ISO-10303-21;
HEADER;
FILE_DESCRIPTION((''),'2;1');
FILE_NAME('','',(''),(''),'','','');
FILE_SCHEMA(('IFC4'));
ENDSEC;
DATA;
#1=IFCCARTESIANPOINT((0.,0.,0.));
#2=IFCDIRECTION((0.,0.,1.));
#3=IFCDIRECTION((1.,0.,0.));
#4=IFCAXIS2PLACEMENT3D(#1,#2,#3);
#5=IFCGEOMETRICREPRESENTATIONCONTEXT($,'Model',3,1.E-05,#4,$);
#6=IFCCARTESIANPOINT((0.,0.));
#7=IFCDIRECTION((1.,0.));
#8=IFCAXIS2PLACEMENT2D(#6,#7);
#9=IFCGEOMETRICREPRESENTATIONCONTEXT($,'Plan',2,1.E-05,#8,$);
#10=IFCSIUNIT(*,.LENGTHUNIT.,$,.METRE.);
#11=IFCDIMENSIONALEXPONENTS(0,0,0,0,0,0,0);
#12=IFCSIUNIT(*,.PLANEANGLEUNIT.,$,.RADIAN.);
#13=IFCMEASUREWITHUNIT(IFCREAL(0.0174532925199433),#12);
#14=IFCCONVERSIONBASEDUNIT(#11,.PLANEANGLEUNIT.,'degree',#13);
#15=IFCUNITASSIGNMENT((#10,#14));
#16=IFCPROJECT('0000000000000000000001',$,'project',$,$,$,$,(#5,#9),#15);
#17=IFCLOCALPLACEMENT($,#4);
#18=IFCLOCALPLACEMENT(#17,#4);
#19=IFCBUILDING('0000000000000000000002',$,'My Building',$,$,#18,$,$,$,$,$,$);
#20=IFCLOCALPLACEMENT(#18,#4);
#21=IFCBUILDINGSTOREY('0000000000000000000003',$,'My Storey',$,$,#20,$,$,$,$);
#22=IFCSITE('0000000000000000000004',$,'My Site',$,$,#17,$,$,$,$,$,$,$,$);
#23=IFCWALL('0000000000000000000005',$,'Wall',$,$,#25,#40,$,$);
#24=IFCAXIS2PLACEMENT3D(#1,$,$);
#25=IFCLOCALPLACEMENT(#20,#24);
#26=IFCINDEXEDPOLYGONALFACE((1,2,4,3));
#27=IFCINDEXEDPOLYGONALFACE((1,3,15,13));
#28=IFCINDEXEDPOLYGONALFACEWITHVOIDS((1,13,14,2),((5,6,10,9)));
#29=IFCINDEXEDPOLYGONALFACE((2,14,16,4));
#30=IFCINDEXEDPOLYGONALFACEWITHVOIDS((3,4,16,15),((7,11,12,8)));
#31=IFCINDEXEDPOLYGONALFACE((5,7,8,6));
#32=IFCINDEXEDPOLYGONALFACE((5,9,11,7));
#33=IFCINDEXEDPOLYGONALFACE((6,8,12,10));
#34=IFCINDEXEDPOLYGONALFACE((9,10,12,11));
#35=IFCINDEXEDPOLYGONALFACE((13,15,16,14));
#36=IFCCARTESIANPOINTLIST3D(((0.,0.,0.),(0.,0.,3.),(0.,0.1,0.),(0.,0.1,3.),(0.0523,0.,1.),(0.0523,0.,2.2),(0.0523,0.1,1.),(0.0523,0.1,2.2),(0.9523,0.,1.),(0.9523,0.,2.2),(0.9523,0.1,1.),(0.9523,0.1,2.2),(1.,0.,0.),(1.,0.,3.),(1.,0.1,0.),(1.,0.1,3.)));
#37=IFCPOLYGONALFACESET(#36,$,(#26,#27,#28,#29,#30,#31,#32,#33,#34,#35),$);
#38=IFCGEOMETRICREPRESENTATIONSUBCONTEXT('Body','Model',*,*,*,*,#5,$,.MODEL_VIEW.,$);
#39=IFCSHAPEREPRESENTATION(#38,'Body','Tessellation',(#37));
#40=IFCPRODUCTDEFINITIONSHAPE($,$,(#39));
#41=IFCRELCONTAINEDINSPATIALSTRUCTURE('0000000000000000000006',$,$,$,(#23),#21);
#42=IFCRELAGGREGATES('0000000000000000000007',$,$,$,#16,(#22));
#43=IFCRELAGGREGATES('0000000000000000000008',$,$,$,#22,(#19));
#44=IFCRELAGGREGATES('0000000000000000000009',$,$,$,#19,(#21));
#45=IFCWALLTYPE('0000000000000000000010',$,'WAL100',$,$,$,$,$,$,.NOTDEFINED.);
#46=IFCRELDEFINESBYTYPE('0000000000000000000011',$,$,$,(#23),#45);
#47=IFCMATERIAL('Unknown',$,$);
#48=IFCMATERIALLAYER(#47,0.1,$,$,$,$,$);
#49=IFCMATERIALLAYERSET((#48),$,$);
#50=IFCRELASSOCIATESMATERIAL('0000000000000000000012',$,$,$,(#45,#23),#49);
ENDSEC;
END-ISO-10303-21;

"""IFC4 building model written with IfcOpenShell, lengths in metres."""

from ifc_helpers import new_model, entity, si_unit, converted_unit, frame, origin_with_axes, origin_2d_with_axis, place, context, subcontext, project, spatial, line, indexed_curve, outline, extrude, source, transform, mapped, material, layer, layer_set, layer_usage, type_object, element, save


model = new_model("IFC4")

# Units and contexts
model_context = context("Model", 3, precision=1e-05, world=origin_with_axes())
plan_context = context("Plan", 2, precision=1e-05, world=origin_2d_with_axis())
body_context = subcontext(model_context, "Body", "Model", "MODEL_VIEW")
ifc_project = project(units=[si_unit("LENGTHUNIT", "METRE"), converted_unit("PLANEANGLEUNIT", "degree", entity("IfcReal", 0.0174532925199433), si_unit("PLANEANGLEUNIT", "RADIAN"), dimensions=[0, 0, 0, 0, 0, 0, 0])], contexts=[model_context, plan_context])

# Site, building, storey
site_placement = place(None, origin_with_axes())
site = spatial("IfcSite", under=ifc_project, at=site_placement, Name="My Site")
building_placement = place(site_placement, origin_with_axes())
building = spatial("IfcBuilding", under=site, at=building_placement, Name="My Building")
storey_placement = place(building_placement, origin_with_axes())
storey = spatial("IfcBuildingStorey", under=building, at=storey_placement, Name="My Storey")

# Wall, opening
ifc_material = material(Name="Unknown")
ifc_layer = layer(ifc_material, 0.1)
ifc_layer_set = layer_set([ifc_layer])
ifc_layer_usage = layer_usage(ifc_layer_set, "AXIS2", "POSITIVE", 0.0)
wall_type = type_object("IfcWallType", Name="WAL100", PredefinedType="NOTDEFINED", material=ifc_layer_set)
wall_placement = place(storey_placement, origin_with_axes())
wall = element("IfcWall", 1, at=wall_placement, inside=storey, type_object=wall_type, material=ifc_layer_usage, Name="Wall", context=body_context, shape_type="SweptSolid", body=[
    extrude(outline(indexed_curve([(0.0, 0.0), (0.0, 0.1), (1.0, 0.1), (1.0, 0.0), (0.0, 0.0)], self_intersect=False)), origin_with_axes(), (0.0, 0.0, 1.0), 3.0),
])
shared_shape = source(origin_with_axes(), body_context, "Body", "SweptSolid", [
    extrude(outline(indexed_curve([(0.0, 0.0), (0.9, 0.0), (0.9, 1.2), (0.0, 1.2)], segments=[line(1, 2, 3, 4, 1)])), frame((0.0, -0.6, 0.0), z_axis=(0.0, -1.0, 0.0), x_axis=(1.0, 0.0, 0.0)), (0.0, 0.0, -1.0), 1.2),
])
opening_placement = place(wall_placement, frame((0.0523, 0.0, 1.0), z_axis=(0.0, 0.0, 1.0), x_axis=(1.0, 0.0, 0.0)))
element("IfcOpeningElement", 2, at=opening_placement, cuts=wall, PredefinedType="OPENING", context=body_context, shape_type="MappedRepresentation", body=[
    mapped(shared_shape, transform((0.0, 0.0, 0.0), x_axis=(1.0, 0.0, 0.0), y_axis=(0.0, 1.0, 0.0), z_axis=(0.0, 0.0, 1.0), scale=1.0)),
])

save(model, "model.ifc")
